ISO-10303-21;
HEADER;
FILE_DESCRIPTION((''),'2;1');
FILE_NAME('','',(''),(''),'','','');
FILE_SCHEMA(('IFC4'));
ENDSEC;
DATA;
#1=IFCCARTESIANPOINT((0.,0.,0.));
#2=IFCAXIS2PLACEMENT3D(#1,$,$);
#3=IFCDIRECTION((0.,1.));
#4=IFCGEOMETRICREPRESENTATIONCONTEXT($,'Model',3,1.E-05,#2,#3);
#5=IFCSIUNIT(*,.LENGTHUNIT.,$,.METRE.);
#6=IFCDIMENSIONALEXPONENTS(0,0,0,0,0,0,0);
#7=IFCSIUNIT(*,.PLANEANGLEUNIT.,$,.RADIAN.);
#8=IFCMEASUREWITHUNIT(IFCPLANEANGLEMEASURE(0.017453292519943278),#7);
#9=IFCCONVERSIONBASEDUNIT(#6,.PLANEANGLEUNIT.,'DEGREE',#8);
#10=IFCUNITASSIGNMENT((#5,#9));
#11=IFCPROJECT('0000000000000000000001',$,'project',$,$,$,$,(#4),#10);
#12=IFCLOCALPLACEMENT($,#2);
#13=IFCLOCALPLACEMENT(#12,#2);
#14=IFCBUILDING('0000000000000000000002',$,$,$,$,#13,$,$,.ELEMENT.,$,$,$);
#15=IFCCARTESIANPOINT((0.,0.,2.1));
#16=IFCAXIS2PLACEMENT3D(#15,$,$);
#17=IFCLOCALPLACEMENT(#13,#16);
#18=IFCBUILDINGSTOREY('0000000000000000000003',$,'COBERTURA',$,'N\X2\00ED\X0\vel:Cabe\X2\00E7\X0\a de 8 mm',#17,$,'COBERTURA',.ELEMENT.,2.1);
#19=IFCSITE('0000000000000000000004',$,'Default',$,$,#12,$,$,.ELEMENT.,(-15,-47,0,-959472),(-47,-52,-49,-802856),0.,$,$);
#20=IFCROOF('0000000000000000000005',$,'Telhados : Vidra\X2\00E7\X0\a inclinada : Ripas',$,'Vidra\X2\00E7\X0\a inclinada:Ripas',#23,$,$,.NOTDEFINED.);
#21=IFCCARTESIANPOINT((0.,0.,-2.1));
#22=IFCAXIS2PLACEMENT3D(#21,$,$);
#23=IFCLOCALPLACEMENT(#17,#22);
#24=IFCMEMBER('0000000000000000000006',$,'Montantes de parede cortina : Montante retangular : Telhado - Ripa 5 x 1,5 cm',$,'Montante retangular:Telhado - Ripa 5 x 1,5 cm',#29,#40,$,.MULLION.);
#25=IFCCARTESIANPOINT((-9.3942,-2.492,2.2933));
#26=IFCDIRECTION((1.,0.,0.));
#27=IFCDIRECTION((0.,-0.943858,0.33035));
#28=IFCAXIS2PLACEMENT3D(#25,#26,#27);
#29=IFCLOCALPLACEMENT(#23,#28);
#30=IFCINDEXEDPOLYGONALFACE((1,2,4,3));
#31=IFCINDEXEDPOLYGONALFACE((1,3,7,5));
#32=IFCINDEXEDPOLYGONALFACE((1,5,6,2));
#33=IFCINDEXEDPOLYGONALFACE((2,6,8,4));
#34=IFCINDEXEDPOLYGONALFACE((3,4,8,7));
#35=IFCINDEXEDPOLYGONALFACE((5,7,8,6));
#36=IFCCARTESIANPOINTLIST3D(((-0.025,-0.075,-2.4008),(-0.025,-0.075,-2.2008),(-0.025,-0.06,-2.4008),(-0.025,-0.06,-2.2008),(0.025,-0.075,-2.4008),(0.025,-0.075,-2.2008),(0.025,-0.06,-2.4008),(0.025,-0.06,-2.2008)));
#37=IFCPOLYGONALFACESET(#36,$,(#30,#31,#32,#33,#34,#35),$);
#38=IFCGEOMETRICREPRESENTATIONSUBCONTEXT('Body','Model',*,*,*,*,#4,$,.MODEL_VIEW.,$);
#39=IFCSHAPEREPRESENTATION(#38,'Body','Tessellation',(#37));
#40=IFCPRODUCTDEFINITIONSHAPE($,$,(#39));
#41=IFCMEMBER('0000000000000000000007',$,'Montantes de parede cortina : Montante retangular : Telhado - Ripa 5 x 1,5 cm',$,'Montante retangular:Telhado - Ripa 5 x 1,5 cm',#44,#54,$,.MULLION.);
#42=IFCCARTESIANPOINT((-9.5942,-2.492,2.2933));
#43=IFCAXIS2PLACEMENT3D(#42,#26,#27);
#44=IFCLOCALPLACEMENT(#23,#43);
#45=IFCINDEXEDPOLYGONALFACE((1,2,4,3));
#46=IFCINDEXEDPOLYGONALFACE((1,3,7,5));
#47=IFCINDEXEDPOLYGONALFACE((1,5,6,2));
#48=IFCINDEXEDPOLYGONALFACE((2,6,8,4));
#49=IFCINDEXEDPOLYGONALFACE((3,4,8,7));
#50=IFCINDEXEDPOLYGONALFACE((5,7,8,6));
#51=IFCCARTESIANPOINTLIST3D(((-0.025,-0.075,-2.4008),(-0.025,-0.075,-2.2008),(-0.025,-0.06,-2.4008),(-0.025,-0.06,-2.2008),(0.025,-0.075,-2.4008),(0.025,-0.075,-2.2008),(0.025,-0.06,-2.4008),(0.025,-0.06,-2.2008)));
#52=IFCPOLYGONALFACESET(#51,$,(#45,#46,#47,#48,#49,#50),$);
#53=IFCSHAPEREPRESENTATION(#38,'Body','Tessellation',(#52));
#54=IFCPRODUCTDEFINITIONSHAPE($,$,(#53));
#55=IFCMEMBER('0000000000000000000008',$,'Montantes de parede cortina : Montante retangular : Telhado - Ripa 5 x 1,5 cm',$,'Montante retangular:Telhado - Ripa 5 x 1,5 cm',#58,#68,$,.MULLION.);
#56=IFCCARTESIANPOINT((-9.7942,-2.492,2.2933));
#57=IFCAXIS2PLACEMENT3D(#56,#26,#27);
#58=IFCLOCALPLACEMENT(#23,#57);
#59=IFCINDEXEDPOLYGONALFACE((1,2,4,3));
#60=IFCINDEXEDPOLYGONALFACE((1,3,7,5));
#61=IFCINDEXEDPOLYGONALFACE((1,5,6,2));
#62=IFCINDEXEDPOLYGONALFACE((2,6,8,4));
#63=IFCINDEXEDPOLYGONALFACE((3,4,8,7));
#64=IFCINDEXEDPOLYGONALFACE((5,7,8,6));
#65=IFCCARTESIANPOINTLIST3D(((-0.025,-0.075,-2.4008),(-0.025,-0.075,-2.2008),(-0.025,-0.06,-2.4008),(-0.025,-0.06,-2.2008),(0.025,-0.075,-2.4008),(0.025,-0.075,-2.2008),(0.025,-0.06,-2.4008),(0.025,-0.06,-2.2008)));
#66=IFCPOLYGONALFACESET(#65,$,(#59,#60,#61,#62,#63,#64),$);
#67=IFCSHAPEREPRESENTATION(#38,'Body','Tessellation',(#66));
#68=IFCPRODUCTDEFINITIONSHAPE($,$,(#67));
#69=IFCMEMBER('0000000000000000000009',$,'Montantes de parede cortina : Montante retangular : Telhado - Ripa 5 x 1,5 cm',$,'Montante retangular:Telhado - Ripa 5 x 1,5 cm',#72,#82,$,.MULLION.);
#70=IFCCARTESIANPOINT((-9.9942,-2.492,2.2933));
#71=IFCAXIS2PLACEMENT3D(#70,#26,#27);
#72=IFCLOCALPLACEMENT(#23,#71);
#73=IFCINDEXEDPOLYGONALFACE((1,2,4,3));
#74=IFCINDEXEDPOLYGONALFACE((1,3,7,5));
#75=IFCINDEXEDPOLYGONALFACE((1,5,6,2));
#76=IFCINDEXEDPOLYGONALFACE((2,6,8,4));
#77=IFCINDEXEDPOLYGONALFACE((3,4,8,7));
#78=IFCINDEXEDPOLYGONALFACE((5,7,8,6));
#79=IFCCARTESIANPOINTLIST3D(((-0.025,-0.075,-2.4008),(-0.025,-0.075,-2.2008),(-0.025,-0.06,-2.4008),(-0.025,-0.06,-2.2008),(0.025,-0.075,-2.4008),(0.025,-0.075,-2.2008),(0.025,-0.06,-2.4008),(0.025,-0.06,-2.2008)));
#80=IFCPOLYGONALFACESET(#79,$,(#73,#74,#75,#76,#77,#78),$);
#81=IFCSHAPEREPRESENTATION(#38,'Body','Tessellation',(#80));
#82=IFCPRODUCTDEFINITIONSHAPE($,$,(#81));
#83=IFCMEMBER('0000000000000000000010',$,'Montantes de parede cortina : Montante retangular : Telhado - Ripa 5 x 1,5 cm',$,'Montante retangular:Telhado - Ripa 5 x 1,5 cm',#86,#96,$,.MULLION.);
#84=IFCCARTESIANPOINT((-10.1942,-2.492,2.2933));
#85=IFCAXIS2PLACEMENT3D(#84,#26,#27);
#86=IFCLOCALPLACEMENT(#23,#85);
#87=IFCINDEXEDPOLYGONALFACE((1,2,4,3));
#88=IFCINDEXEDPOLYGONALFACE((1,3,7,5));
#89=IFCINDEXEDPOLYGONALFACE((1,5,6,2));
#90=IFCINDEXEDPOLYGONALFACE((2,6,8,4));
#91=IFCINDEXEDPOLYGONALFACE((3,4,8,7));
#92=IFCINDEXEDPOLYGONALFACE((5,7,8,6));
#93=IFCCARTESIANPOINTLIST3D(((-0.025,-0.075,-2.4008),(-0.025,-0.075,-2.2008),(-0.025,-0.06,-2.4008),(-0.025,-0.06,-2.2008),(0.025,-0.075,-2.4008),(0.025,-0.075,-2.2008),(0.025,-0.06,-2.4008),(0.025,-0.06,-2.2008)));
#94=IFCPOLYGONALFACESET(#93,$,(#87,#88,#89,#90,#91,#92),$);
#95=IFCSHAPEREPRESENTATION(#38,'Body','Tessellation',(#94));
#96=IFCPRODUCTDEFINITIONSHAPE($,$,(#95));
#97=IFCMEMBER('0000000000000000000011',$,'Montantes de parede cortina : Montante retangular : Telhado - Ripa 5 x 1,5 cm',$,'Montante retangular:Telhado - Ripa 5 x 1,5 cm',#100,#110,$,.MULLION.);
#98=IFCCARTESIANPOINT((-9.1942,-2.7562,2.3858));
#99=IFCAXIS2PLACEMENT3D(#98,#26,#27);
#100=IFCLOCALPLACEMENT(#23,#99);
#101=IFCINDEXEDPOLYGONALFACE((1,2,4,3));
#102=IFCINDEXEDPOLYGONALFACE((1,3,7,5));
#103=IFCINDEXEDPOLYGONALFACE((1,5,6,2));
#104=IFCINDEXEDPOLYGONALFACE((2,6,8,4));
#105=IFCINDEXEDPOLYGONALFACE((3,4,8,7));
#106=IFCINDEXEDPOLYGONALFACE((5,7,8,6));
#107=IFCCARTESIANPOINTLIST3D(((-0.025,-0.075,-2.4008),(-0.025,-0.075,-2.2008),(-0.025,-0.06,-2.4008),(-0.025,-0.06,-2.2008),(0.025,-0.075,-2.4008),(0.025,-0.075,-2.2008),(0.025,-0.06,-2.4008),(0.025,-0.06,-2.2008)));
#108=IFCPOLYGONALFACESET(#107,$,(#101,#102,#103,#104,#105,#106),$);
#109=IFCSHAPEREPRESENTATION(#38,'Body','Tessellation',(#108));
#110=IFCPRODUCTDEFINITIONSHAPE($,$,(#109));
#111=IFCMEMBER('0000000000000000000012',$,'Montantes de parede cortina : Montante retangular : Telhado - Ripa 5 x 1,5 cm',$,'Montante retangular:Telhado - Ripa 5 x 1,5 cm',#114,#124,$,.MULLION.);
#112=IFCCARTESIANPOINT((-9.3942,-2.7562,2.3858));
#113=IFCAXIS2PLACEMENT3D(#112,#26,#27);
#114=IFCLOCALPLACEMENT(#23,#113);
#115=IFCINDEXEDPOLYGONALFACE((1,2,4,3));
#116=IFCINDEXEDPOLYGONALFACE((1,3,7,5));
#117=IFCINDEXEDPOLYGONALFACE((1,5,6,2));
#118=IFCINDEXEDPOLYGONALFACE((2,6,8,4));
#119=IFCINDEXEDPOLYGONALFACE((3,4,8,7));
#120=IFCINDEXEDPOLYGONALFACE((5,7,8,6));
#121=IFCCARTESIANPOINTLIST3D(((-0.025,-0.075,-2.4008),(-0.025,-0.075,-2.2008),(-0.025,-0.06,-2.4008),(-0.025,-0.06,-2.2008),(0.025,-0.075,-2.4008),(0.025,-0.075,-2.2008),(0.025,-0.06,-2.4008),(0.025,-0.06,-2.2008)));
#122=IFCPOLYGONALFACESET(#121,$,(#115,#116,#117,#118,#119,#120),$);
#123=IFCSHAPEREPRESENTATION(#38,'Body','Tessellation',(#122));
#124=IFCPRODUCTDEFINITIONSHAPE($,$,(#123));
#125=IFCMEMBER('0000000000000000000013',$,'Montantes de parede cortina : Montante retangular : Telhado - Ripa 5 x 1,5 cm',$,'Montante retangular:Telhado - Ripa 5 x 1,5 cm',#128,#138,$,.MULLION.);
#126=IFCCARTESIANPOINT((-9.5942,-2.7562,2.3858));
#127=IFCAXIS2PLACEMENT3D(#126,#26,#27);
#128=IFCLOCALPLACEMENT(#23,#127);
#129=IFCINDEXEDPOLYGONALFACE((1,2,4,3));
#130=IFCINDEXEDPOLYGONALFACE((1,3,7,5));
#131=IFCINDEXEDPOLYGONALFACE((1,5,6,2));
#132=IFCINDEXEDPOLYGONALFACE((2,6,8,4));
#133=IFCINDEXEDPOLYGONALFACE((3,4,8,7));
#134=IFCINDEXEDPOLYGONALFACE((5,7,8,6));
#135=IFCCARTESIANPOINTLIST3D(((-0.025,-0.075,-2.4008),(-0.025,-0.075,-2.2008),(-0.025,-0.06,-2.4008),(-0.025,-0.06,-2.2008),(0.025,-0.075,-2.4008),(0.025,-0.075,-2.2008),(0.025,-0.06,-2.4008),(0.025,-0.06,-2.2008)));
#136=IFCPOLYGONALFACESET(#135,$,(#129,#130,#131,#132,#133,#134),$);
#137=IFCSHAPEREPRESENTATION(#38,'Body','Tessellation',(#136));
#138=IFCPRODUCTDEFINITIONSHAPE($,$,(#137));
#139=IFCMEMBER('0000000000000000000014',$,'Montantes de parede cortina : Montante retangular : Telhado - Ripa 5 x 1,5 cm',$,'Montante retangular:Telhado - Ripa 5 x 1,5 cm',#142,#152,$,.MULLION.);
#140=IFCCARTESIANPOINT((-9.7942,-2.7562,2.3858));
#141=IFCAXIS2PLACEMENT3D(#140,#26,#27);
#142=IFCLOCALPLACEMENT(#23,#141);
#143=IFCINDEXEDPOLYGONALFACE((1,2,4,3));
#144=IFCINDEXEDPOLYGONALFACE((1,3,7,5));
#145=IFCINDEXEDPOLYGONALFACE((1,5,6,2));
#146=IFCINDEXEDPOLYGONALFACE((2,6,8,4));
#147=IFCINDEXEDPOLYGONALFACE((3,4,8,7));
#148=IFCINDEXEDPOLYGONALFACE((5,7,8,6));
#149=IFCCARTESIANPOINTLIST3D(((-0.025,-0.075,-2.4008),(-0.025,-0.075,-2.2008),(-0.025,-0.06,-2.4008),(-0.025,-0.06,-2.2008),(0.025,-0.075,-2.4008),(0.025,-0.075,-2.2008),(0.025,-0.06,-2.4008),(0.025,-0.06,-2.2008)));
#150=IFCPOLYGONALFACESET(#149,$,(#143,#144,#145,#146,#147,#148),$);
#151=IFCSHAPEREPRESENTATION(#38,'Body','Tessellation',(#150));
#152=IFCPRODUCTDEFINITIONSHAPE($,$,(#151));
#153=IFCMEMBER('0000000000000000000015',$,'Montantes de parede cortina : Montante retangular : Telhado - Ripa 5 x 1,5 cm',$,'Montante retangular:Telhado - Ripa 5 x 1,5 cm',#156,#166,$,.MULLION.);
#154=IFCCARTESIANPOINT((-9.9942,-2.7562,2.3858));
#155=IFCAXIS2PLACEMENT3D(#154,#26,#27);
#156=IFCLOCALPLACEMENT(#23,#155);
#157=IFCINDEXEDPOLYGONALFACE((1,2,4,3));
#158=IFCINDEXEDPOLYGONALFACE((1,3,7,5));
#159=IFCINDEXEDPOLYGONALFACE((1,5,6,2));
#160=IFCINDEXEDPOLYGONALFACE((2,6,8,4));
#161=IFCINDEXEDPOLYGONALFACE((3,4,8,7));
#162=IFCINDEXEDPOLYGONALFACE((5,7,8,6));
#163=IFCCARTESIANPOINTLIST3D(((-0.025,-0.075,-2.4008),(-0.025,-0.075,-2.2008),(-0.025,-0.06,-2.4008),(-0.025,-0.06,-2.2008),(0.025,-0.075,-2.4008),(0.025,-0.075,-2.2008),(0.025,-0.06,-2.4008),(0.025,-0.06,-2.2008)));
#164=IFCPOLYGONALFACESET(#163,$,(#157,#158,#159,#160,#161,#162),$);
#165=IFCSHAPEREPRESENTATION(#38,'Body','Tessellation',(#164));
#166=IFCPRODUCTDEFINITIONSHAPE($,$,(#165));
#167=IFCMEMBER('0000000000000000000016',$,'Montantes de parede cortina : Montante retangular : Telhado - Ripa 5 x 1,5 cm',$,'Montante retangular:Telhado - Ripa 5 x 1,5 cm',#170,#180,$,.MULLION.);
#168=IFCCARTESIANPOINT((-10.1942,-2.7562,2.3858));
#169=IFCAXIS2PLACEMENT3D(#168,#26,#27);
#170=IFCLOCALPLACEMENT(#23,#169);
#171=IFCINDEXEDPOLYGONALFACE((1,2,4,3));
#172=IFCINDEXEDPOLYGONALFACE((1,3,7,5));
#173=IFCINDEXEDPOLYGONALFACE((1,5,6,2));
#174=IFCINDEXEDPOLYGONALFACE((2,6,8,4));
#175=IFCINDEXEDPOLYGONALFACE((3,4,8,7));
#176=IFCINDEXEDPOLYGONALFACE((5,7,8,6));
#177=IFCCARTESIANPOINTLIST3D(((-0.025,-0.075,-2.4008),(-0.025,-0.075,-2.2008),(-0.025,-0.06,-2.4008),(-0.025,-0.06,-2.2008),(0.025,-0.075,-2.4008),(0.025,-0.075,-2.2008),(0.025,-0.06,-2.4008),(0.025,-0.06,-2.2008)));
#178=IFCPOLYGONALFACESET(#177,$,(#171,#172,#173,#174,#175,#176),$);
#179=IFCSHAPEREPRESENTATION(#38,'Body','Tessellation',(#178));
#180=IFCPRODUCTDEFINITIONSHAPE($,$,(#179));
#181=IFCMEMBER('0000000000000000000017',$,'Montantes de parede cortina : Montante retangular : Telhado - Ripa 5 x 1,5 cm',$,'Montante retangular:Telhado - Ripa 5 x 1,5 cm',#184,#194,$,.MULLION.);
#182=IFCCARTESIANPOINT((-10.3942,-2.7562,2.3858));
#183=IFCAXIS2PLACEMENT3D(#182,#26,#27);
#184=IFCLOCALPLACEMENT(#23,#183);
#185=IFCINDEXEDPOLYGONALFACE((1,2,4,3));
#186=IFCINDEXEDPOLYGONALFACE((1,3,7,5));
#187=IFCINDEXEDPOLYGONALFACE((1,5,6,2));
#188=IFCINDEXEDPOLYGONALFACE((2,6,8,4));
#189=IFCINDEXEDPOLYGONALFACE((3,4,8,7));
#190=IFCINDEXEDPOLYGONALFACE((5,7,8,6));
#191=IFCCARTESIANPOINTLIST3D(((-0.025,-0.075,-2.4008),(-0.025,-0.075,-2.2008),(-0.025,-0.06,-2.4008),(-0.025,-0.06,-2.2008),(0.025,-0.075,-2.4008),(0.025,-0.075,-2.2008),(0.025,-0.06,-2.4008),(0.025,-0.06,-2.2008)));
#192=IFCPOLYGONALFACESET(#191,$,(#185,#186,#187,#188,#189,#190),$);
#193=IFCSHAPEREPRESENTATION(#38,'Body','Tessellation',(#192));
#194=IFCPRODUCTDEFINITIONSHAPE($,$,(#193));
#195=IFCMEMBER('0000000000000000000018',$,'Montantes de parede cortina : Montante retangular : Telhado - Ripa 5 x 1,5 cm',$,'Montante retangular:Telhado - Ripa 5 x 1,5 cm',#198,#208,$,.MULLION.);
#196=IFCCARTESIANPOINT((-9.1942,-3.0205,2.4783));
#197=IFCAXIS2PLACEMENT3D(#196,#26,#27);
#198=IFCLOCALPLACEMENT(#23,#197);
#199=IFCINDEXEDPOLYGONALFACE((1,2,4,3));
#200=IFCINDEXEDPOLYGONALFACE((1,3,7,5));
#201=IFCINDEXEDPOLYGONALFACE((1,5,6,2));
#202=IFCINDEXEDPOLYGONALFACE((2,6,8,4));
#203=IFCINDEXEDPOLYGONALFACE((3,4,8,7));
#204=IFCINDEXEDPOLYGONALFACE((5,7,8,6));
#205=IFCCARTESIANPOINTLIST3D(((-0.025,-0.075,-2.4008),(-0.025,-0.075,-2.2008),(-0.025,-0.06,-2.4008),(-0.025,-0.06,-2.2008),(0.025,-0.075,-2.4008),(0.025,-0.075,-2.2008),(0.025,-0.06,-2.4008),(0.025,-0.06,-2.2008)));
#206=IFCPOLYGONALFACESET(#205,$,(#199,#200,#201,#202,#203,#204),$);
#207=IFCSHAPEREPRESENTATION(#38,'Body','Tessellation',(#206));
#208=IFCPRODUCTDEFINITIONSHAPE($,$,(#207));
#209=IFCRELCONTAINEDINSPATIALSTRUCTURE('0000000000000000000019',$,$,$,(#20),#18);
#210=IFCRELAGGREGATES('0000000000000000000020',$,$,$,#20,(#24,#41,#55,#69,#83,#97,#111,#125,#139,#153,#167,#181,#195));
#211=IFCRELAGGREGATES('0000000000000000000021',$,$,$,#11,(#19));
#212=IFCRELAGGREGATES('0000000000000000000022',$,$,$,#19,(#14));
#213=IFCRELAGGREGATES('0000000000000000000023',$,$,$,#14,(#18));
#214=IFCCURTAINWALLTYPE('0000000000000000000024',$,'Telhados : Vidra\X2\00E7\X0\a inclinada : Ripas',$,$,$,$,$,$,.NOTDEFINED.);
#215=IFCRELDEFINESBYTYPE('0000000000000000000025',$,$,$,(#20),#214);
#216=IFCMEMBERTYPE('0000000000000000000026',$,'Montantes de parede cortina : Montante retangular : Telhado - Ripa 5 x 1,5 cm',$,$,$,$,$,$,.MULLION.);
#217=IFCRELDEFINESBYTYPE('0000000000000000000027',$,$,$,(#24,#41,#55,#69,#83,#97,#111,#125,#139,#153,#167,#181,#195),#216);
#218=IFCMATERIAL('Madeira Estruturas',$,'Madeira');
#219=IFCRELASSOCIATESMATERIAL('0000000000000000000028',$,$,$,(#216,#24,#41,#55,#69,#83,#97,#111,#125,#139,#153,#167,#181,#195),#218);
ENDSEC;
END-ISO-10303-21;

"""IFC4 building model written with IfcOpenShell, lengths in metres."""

from ifc_helpers import new_model, entity, si_unit, converted_unit, direction, frame, origin, place, context, subcontext, project, spatial, indexed_curve, outline, extrude, source, transform, mapped, material, type_object, type_shapes, element, aggregate, save


model = new_model("IFC4")

# Units and contexts
model_context = context("Model", 3, precision=1e-05, world=origin(), true_north=direction((0.0, 1.0)))
body_context = subcontext(model_context, "Body", "Model", "MODEL_VIEW")
ifc_project = project(units=[si_unit("LENGTHUNIT", "METRE"), converted_unit("PLANEANGLEUNIT", "DEGREE", entity("IfcPlaneAngleMeasure", 0.017453292519943278), si_unit("PLANEANGLEUNIT", "RADIAN"), dimensions=[0, 0, 0, 0, 0, 0, 0])], contexts=[model_context])

# Site, building, storey
site_placement = place(None, origin())
site = spatial("IfcSite", under=ifc_project, at=site_placement, Name="Default", CompositionType="ELEMENT", RefLatitude=(-15, -47, 0, -959472), RefLongitude=(-47, -52, -49, -802856), RefElevation=0.0)
building_placement = place(site_placement, origin())
building = spatial("IfcBuilding", under=site, at=building_placement, CompositionType="ELEMENT")
storey_placement = place(building_placement, frame((0.0, 0.0, 2.1)))
storey = spatial("IfcBuildingStorey", under=building, at=storey_placement, Name="COBERTURA", ObjectType="Nível:Cabeça de 8 mm", LongName="COBERTURA", CompositionType="ELEMENT", Elevation=2.1)

# Roof, members
curtain_wall_type_1 = type_object("IfcCurtainWallType", Name="Telhados : Vidraça inclinada : Ripas", PredefinedType="NOTDEFINED")
roof_1_placement = place(storey_placement, frame((0.0, 0.0, -2.1)))
roof_1 = element("IfcRoof", 1, at=roof_1_placement, inside=storey, type_object=curtain_wall_type_1, Name="Telhados : Vidraça inclinada : Ripas", ObjectType="Vidraça inclinada:Ripas", PredefinedType="NOTDEFINED")
ifc_material_1 = material(Name="Madeira Estruturas", Category="Madeira")
member_type_1 = type_object("IfcMemberType", Name="Montantes de parede cortina : Montante retangular : Telhado - Ripa 5 x 1,5 cm", PredefinedType="MULLION", material=ifc_material_1)
shared_shape_1 = source(origin(), body_context, "Body", "SweptSolid", [
    extrude(outline(indexed_curve([(-0.025, -0.0075), (0.025, -0.0075), (0.025, 0.0075), (-0.025, 0.0075), (-0.025, -0.0075)], self_intersect=False)), frame((0.0, -0.0675, -2.4008), z_axis=(0.0, 0.0, 1.0), x_axis=(-1.0, 0.0, 0.0)), (0.0, 0.0, 1.0), 0.2),
])
type_shapes(member_type_1, [shared_shape_1])
member_1_placement = place(roof_1_placement, frame((-9.3942, -2.492, 2.2933), z_axis=(1.0, 0.0, 0.0), x_axis=(0.0, -0.943858, 0.33035)))
member_1 = element("IfcMember", 2, at=member_1_placement, type_object=member_type_1, material=ifc_material_1, Name="Montantes de parede cortina : Montante retangular : Telhado - Ripa 5 x 1,5 cm", ObjectType="Montante retangular:Telhado - Ripa 5 x 1,5 cm", PredefinedType="MULLION", context=body_context, shape_type="MappedRepresentation", body=[
    mapped(shared_shape_1, transform((0.0, 0.0, 0.0), scale=1.0)),
])
member_2_placement = place(roof_1_placement, frame((-9.5942, -2.492, 2.2933), z_axis=(1.0, 0.0, 0.0), x_axis=(0.0, -0.943858, 0.33035)))
member_2 = element("IfcMember", 3, at=member_2_placement, type_object=member_type_1, material=ifc_material_1, Name="Montantes de parede cortina : Montante retangular : Telhado - Ripa 5 x 1,5 cm", ObjectType="Montante retangular:Telhado - Ripa 5 x 1,5 cm", PredefinedType="MULLION", context=body_context, shape_type="MappedRepresentation", body=[
    mapped(shared_shape_1, transform((0.0, 0.0, 0.0), scale=1.0)),
])
member_3_placement = place(roof_1_placement, frame((-9.7942, -2.492, 2.2933), z_axis=(1.0, 0.0, 0.0), x_axis=(0.0, -0.943858, 0.33035)))
member_3 = element("IfcMember", 4, at=member_3_placement, type_object=member_type_1, material=ifc_material_1, Name="Montantes de parede cortina : Montante retangular : Telhado - Ripa 5 x 1,5 cm", ObjectType="Montante retangular:Telhado - Ripa 5 x 1,5 cm", PredefinedType="MULLION", context=body_context, shape_type="MappedRepresentation", body=[
    mapped(shared_shape_1, transform((0.0, 0.0, 0.0), scale=1.0)),
])
member_4_placement = place(roof_1_placement, frame((-9.9942, -2.492, 2.2933), z_axis=(1.0, 0.0, 0.0), x_axis=(0.0, -0.943858, 0.33035)))
member_4 = element("IfcMember", 5, at=member_4_placement, type_object=member_type_1, material=ifc_material_1, Name="Montantes de parede cortina : Montante retangular : Telhado - Ripa 5 x 1,5 cm", ObjectType="Montante retangular:Telhado - Ripa 5 x 1,5 cm", PredefinedType="MULLION", context=body_context, shape_type="MappedRepresentation", body=[
    mapped(shared_shape_1, transform((0.0, 0.0, 0.0), scale=1.0)),
])
member_5_placement = place(roof_1_placement, frame((-10.1942, -2.492, 2.2933), z_axis=(1.0, 0.0, 0.0), x_axis=(0.0, -0.943858, 0.33035)))
member_5 = element("IfcMember", 6, at=member_5_placement, type_object=member_type_1, material=ifc_material_1, Name="Montantes de parede cortina : Montante retangular : Telhado - Ripa 5 x 1,5 cm", ObjectType="Montante retangular:Telhado - Ripa 5 x 1,5 cm", PredefinedType="MULLION", context=body_context, shape_type="MappedRepresentation", body=[
    mapped(shared_shape_1, transform((0.0, 0.0, 0.0), scale=1.0)),
])
member_6_placement = place(roof_1_placement, frame((-9.1942, -2.7562, 2.3858), z_axis=(1.0, 0.0, 0.0), x_axis=(0.0, -0.943858, 0.33035)))
member_6 = element("IfcMember", 7, at=member_6_placement, type_object=member_type_1, material=ifc_material_1, Name="Montantes de parede cortina : Montante retangular : Telhado - Ripa 5 x 1,5 cm", ObjectType="Montante retangular:Telhado - Ripa 5 x 1,5 cm", PredefinedType="MULLION", context=body_context, shape_type="MappedRepresentation", body=[
    mapped(shared_shape_1, transform((0.0, 0.0, 0.0), scale=1.0)),
])
member_7_placement = place(roof_1_placement, frame((-9.3942, -2.7562, 2.3858), z_axis=(1.0, 0.0, 0.0), x_axis=(0.0, -0.943858, 0.33035)))
member_7 = element("IfcMember", 8, at=member_7_placement, type_object=member_type_1, material=ifc_material_1, Name="Montantes de parede cortina : Montante retangular : Telhado - Ripa 5 x 1,5 cm", ObjectType="Montante retangular:Telhado - Ripa 5 x 1,5 cm", PredefinedType="MULLION", context=body_context, shape_type="MappedRepresentation", body=[
    mapped(shared_shape_1, transform((0.0, 0.0, 0.0), scale=1.0)),
])
member_8_placement = place(roof_1_placement, frame((-9.5942, -2.7562, 2.3858), z_axis=(1.0, 0.0, 0.0), x_axis=(0.0, -0.943858, 0.33035)))
member_8 = element("IfcMember", 9, at=member_8_placement, type_object=member_type_1, material=ifc_material_1, Name="Montantes de parede cortina : Montante retangular : Telhado - Ripa 5 x 1,5 cm", ObjectType="Montante retangular:Telhado - Ripa 5 x 1,5 cm", PredefinedType="MULLION", context=body_context, shape_type="MappedRepresentation", body=[
    mapped(shared_shape_1, transform((0.0, 0.0, 0.0), scale=1.0)),
])
member_9_placement = place(roof_1_placement, frame((-9.7942, -2.7562, 2.3858), z_axis=(1.0, 0.0, 0.0), x_axis=(0.0, -0.943858, 0.33035)))
member_9 = element("IfcMember", 10, at=member_9_placement, type_object=member_type_1, material=ifc_material_1, Name="Montantes de parede cortina : Montante retangular : Telhado - Ripa 5 x 1,5 cm", ObjectType="Montante retangular:Telhado - Ripa 5 x 1,5 cm", PredefinedType="MULLION", context=body_context, shape_type="MappedRepresentation", body=[
    mapped(shared_shape_1, transform((0.0, 0.0, 0.0), scale=1.0)),
])
member_10_placement = place(roof_1_placement, frame((-9.9942, -2.7562, 2.3858), z_axis=(1.0, 0.0, 0.0), x_axis=(0.0, -0.943858, 0.33035)))
member_10 = element("IfcMember", 11, at=member_10_placement, type_object=member_type_1, material=ifc_material_1, Name="Montantes de parede cortina : Montante retangular : Telhado - Ripa 5 x 1,5 cm", ObjectType="Montante retangular:Telhado - Ripa 5 x 1,5 cm", PredefinedType="MULLION", context=body_context, shape_type="MappedRepresentation", body=[
    mapped(shared_shape_1, transform((0.0, 0.0, 0.0), scale=1.0)),
])
member_11_placement = place(roof_1_placement, frame((-10.1942, -2.7562, 2.3858), z_axis=(1.0, 0.0, 0.0), x_axis=(0.0, -0.943858, 0.33035)))
member_11 = element("IfcMember", 12, at=member_11_placement, type_object=member_type_1, material=ifc_material_1, Name="Montantes de parede cortina : Montante retangular : Telhado - Ripa 5 x 1,5 cm", ObjectType="Montante retangular:Telhado - Ripa 5 x 1,5 cm", PredefinedType="MULLION", context=body_context, shape_type="MappedRepresentation", body=[
    mapped(shared_shape_1, transform((0.0, 0.0, 0.0), scale=1.0)),
])
member_12_placement = place(roof_1_placement, frame((-10.3942, -2.7562, 2.3858), z_axis=(1.0, 0.0, 0.0), x_axis=(0.0, -0.943858, 0.33035)))
member_12 = element("IfcMember", 13, at=member_12_placement, type_object=member_type_1, material=ifc_material_1, Name="Montantes de parede cortina : Montante retangular : Telhado - Ripa 5 x 1,5 cm", ObjectType="Montante retangular:Telhado - Ripa 5 x 1,5 cm", PredefinedType="MULLION", context=body_context, shape_type="MappedRepresentation", body=[
    mapped(shared_shape_1, transform((0.0, 0.0, 0.0), scale=1.0)),
])
member_13_placement = place(roof_1_placement, frame((-9.1942, -3.0205, 2.4783), z_axis=(1.0, 0.0, 0.0), x_axis=(0.0, -0.943858, 0.33035)))
member_13 = element("IfcMember", 14, at=member_13_placement, type_object=member_type_1, material=ifc_material_1, Name="Montantes de parede cortina : Montante retangular : Telhado - Ripa 5 x 1,5 cm", ObjectType="Montante retangular:Telhado - Ripa 5 x 1,5 cm", PredefinedType="MULLION", context=body_context, shape_type="MappedRepresentation", body=[
    mapped(shared_shape_1, transform((0.0, 0.0, 0.0), scale=1.0)),
])
aggregate(roof_1, [member_1, member_2, member_3, member_4, member_5, member_6, member_7, member_8, member_9, member_10, member_11, member_12, member_13])

save(model, "model.ifc")
